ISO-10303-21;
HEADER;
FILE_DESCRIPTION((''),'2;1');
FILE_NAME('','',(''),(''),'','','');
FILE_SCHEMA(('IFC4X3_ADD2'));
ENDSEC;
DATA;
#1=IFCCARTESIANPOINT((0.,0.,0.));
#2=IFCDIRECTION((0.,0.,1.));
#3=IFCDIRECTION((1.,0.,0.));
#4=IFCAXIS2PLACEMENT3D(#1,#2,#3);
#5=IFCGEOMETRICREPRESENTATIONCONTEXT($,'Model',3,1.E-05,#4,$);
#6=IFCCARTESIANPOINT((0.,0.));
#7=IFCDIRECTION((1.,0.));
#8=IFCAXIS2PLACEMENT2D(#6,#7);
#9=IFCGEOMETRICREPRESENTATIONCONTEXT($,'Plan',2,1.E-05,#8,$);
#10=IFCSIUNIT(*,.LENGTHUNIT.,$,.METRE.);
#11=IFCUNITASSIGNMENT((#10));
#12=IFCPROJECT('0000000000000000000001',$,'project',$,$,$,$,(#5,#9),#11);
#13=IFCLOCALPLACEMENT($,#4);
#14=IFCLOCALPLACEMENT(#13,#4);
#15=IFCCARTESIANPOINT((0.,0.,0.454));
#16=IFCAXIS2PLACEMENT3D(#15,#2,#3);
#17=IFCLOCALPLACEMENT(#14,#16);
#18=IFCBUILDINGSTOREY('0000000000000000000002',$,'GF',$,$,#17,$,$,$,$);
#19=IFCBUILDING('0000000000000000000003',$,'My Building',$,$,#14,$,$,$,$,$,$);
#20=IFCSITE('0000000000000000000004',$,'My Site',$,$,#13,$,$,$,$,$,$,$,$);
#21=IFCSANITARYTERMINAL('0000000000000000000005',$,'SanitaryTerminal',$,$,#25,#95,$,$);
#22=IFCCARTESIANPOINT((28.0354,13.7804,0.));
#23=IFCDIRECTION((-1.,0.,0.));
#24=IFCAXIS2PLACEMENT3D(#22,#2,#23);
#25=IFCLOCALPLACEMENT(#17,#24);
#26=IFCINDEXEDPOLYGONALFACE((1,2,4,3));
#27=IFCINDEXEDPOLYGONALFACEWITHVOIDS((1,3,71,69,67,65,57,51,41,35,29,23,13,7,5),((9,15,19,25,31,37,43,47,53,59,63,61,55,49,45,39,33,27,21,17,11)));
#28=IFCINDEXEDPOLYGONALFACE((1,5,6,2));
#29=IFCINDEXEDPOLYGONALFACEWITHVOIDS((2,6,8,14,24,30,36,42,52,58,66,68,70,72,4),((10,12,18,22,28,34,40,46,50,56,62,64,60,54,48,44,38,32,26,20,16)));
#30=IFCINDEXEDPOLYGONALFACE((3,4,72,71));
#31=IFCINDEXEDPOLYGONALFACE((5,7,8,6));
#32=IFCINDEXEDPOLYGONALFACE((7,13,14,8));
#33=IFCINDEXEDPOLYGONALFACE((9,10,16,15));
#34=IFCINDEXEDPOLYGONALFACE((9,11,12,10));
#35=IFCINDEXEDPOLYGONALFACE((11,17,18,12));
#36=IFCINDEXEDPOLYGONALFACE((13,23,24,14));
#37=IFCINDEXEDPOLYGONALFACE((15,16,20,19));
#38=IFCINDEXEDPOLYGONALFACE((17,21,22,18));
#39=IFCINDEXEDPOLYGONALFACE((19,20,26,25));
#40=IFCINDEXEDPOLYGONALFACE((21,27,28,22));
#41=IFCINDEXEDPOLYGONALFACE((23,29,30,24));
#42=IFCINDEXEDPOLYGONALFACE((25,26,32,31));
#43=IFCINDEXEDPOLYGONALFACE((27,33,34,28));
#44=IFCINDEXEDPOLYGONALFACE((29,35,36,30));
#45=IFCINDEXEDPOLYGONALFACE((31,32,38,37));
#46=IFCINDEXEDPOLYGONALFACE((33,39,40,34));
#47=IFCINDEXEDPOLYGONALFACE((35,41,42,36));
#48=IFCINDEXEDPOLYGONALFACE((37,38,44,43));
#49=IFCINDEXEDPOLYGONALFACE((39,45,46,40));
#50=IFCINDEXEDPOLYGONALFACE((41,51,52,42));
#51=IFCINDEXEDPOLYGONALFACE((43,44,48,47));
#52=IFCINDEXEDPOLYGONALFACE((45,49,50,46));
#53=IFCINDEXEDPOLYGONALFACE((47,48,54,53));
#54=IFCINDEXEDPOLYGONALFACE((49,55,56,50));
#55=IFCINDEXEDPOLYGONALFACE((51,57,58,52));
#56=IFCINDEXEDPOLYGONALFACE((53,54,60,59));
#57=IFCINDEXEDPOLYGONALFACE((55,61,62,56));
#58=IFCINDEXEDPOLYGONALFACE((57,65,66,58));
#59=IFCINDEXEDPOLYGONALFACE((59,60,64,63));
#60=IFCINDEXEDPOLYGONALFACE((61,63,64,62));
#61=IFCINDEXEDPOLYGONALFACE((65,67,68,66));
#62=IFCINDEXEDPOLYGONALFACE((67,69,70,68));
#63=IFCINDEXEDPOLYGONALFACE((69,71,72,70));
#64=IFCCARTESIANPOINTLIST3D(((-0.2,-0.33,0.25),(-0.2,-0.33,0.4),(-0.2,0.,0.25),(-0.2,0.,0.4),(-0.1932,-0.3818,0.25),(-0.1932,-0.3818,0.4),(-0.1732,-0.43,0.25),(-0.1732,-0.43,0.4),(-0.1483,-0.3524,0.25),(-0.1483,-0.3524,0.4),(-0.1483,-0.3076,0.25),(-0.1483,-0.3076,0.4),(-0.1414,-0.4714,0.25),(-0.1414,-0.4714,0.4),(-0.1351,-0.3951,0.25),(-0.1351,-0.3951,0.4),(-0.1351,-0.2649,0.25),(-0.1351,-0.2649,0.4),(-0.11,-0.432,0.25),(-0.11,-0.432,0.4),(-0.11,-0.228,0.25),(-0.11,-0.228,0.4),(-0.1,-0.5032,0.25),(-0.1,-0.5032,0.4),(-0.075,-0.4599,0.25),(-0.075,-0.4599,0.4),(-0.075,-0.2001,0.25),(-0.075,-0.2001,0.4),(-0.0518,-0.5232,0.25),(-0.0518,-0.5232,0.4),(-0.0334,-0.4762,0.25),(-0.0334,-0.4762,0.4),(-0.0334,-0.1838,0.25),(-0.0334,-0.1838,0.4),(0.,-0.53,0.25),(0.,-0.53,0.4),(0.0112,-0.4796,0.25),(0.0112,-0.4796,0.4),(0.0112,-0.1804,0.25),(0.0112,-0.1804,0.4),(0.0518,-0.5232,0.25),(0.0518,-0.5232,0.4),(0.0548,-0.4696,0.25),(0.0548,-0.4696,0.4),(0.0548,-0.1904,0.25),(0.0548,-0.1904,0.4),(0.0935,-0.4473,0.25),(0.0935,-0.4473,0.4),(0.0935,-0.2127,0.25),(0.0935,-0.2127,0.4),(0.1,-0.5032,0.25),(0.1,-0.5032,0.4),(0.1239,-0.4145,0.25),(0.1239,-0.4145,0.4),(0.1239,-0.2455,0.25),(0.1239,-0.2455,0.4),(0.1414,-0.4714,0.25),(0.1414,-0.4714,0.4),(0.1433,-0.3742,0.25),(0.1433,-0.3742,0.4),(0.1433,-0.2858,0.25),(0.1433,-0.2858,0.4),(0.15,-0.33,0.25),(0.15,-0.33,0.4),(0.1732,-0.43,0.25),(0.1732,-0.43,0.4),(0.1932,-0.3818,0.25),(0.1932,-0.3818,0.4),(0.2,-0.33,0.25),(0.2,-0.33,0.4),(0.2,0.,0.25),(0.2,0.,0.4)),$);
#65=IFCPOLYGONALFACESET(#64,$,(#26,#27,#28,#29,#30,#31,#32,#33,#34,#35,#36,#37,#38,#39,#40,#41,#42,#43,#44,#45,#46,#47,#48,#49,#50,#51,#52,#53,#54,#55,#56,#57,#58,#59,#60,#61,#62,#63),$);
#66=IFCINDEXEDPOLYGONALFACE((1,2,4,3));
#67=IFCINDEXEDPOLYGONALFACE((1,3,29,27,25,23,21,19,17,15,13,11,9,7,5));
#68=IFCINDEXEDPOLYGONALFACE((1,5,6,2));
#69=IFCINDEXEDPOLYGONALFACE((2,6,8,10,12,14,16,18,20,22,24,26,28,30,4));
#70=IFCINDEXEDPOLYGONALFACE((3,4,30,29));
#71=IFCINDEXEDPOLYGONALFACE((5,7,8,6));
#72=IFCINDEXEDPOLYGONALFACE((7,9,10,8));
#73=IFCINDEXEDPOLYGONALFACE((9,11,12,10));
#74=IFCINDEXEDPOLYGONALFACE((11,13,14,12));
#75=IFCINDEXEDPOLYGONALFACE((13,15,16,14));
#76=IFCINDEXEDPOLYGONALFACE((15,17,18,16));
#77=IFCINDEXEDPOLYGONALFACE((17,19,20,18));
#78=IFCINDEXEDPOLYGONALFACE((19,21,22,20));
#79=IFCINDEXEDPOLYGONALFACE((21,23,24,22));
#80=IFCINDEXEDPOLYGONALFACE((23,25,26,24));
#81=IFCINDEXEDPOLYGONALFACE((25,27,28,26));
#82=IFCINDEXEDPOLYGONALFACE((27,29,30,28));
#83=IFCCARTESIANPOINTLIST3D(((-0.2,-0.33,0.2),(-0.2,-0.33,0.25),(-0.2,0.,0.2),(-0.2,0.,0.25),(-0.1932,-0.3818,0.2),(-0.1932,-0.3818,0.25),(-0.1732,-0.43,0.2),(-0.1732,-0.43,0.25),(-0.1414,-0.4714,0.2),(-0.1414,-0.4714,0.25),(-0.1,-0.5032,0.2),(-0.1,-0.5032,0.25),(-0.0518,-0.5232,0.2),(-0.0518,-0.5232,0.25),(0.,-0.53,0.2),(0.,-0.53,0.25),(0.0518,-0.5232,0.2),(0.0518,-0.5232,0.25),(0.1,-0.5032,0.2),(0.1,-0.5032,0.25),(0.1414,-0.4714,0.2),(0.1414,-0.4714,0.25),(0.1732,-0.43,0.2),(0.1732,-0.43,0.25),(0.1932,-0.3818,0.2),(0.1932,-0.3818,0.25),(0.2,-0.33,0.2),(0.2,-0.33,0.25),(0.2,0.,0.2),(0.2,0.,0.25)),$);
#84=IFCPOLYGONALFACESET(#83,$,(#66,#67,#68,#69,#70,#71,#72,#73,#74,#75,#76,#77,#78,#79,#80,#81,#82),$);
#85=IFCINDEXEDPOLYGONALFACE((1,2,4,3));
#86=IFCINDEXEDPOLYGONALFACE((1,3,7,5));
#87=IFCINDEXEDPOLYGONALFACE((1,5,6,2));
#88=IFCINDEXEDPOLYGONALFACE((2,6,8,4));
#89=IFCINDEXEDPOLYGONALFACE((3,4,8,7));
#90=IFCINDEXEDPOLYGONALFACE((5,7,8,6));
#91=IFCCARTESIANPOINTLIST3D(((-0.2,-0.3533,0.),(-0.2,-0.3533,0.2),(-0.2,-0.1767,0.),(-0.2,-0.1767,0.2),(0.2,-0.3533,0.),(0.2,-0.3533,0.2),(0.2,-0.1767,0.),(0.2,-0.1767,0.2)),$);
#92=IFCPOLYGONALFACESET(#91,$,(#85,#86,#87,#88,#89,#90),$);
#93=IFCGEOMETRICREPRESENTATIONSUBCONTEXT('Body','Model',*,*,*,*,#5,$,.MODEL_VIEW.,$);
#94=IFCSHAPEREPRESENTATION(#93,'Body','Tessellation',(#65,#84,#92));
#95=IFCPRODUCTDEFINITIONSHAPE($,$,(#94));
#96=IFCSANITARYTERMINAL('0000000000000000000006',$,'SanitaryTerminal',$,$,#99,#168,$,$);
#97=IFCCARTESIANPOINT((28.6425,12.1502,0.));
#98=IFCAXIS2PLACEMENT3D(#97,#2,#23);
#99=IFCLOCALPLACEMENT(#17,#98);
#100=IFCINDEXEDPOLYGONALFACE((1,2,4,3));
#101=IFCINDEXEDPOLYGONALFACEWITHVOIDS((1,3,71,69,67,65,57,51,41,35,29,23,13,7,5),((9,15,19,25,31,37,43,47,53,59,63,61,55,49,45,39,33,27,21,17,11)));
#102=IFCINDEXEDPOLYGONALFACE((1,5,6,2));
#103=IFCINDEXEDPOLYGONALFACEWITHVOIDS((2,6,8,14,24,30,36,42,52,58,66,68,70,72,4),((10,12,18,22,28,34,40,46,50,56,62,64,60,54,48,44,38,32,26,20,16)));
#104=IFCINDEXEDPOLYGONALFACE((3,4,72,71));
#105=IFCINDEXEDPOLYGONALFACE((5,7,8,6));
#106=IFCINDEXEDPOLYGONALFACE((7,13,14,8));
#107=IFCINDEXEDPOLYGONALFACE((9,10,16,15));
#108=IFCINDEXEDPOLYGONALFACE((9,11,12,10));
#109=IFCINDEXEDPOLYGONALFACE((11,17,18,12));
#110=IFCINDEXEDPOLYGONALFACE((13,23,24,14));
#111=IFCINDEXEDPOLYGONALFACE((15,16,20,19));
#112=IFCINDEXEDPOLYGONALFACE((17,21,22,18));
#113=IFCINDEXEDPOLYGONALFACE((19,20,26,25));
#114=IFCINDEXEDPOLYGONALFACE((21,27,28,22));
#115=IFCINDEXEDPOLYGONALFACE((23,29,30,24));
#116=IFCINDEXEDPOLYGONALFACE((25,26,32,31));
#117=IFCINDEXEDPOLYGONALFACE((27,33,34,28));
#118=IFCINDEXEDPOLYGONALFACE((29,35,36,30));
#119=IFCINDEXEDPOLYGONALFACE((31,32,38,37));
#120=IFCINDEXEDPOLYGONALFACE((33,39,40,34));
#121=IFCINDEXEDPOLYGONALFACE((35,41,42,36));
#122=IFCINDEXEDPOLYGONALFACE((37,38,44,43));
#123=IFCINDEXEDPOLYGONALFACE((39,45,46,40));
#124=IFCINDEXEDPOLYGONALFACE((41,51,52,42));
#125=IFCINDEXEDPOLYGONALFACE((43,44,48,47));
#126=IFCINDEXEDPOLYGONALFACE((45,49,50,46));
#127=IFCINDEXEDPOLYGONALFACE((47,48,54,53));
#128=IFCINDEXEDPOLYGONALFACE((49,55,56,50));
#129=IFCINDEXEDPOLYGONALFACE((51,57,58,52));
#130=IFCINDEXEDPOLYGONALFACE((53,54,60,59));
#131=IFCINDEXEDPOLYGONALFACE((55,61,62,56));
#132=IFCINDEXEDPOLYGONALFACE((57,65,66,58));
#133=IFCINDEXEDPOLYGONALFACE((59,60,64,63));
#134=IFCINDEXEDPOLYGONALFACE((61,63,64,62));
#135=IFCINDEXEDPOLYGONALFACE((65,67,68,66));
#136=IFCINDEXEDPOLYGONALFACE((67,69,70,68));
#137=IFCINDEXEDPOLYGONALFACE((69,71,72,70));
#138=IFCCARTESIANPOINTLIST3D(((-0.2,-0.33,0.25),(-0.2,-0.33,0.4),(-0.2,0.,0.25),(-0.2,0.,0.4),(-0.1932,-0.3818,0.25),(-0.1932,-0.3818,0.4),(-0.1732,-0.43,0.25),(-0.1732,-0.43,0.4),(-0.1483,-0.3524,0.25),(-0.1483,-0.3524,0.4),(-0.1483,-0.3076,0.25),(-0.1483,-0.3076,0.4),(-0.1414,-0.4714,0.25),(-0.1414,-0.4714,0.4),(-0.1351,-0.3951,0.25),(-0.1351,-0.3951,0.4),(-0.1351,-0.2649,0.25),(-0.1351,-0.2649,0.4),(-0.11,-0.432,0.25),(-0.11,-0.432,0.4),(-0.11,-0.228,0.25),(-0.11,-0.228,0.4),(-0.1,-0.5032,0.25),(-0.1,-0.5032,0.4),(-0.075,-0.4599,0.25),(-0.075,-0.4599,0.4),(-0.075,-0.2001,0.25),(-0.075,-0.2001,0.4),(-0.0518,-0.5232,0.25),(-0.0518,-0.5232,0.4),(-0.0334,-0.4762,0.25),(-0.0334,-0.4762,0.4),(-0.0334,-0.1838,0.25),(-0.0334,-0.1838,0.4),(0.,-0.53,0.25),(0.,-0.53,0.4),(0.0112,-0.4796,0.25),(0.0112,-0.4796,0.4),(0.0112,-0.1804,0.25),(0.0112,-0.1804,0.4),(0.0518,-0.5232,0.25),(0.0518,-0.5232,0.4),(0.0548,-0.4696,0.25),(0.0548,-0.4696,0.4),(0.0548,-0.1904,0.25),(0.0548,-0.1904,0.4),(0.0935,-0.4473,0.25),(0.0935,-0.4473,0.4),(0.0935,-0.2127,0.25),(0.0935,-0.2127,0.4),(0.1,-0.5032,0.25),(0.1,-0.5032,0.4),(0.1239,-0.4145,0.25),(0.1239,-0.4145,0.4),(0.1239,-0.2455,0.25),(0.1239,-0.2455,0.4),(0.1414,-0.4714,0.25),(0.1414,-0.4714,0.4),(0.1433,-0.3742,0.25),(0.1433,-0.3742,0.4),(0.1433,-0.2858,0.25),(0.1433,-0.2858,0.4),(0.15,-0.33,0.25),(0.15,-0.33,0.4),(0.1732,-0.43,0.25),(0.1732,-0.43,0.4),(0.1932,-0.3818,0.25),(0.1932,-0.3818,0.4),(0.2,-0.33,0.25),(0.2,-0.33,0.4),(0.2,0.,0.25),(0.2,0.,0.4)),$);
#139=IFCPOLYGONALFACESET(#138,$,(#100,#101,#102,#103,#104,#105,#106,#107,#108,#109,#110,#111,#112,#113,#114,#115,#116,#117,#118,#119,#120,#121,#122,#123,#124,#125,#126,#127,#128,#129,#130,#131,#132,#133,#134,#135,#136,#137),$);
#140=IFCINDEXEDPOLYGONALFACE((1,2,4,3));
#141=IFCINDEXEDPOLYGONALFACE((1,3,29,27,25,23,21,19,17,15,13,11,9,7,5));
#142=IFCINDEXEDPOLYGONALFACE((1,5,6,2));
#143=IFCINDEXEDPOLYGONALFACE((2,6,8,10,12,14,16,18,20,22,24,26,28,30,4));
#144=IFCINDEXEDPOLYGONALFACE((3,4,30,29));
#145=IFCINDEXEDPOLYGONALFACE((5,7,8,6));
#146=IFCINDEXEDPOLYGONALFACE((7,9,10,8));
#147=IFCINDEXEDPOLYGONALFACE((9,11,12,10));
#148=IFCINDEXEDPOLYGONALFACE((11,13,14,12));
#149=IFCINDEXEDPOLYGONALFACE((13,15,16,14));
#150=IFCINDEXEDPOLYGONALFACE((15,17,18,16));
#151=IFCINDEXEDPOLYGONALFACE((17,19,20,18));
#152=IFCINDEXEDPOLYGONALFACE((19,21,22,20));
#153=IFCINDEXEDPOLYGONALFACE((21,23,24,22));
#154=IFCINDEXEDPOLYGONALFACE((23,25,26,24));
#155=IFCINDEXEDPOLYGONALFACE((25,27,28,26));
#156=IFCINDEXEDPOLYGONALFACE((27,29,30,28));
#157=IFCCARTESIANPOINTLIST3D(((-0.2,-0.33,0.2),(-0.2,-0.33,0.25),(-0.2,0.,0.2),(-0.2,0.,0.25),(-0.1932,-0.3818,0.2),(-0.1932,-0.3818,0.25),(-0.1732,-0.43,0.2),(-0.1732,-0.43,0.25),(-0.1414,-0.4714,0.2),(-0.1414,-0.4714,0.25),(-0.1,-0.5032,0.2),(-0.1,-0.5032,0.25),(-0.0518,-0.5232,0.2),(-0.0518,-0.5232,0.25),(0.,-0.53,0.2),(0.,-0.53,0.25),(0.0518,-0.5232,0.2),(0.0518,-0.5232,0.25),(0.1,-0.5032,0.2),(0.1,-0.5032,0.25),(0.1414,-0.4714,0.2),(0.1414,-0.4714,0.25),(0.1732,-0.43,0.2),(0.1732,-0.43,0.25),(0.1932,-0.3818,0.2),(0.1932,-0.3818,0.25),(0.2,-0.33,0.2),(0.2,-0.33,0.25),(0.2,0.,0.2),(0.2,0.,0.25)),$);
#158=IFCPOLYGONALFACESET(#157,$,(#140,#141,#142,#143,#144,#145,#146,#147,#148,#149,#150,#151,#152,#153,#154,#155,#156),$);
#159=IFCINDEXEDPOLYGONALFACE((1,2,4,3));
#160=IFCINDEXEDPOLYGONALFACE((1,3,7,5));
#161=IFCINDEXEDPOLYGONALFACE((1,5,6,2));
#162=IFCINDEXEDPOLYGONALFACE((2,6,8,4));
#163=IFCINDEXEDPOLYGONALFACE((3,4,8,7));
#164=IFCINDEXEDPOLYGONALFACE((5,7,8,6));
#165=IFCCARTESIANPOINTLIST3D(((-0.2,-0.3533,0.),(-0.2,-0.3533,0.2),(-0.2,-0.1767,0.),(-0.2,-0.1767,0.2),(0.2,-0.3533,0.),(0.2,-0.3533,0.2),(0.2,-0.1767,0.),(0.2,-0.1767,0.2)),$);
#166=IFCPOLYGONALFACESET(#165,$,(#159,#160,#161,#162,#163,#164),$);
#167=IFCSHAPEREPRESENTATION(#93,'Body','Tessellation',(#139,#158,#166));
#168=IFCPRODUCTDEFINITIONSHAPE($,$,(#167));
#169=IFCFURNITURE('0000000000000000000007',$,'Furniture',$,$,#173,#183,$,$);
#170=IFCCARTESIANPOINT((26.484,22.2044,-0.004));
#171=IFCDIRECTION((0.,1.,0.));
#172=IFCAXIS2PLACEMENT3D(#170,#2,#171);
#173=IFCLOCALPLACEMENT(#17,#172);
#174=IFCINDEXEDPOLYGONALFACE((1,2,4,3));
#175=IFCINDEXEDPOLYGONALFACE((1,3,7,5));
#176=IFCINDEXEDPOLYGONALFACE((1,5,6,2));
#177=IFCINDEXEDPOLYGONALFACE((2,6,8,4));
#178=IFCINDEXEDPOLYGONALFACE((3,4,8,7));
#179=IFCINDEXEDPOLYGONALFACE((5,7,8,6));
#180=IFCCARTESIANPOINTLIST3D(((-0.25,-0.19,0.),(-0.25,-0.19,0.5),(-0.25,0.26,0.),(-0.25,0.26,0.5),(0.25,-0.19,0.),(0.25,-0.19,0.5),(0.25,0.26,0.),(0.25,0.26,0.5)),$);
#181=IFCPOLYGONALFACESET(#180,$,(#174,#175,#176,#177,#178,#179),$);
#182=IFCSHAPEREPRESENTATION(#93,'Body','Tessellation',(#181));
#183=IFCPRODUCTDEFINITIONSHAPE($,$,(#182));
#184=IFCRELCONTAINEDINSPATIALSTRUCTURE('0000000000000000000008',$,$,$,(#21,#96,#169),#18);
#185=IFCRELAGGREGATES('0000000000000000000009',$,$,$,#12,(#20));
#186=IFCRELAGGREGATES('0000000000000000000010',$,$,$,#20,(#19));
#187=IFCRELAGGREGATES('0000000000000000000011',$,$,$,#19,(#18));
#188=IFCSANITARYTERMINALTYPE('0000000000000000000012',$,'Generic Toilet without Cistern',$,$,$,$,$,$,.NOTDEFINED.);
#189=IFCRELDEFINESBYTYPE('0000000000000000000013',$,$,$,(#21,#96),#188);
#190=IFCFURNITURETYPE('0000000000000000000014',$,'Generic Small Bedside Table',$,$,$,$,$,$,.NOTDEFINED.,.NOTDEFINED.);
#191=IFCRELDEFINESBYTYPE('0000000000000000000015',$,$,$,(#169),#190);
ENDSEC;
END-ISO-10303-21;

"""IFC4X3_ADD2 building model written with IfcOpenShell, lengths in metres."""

from ifc_helpers import new_model, entity, si_unit, frame, frame_2d, origin_with_axes, origin_2d_with_axis, place, context, subcontext, project, spatial, line, arc, indexed_curve, circle_curve, outline, extrude, shape, source, transform, mapped, type_object, type_shapes, element, save


model = new_model("IFC4X3_ADD2")

# Units and contexts
model_context = context("Model", 3, precision=1e-05, world=origin_with_axes())
plan_context = context("Plan", 2, precision=1e-05, world=origin_2d_with_axis())
body_context_1 = subcontext(model_context, "Body", "Model", "MODEL_VIEW")
body_context_2 = subcontext(plan_context, "Body", "Plan", "PLAN_VIEW")
ifc_project = project(units=[si_unit("LENGTHUNIT", "METRE")], contexts=[model_context, plan_context])

# Site, building, storey
site_placement = place(None, origin_with_axes())
site = spatial("IfcSite", under=ifc_project, at=site_placement, Name="My Site")
building_placement = place(site_placement, origin_with_axes())
building = spatial("IfcBuilding", under=site, at=building_placement, Name="My Building")
storey_placement = place(building_placement, frame((0.0, 0.0, 0.454), z_axis=(0.0, 0.0, 1.0), x_axis=(1.0, 0.0, 0.0)))
storey = spatial("IfcBuildingStorey", under=building, at=storey_placement, Name="GF")

# Sanitary terminals
sanitary_terminal_type_1 = type_object("IfcSanitaryTerminalType", Name="Generic Toilet without Cistern", PredefinedType="NOTDEFINED")
shared_shape_1 = source(origin_with_axes(), body_context_1, "Body", "SweptSolid", [
    extrude(outline(indexed_curve([(-0.2, 0.0), (0.2, 0.0), (0.2, -0.33), (0.1414, -0.4714), (0.0, -0.53), (-0.1414, -0.4714), (-0.2, -0.33)], segments=[line(1, 2), line(2, 3), arc(3, 4, 5), arc(5, 6, 7), line(7, 1)]), holes=[circle_curve(frame_2d((0.0, -0.33)), 0.15)]), frame((0.0, 0.0, 0.25), z_axis=(0.0, 0.0, 1.0), x_axis=(1.0, 0.0, 0.0)), (0.0, 0.0, 1.0), 0.15),
    extrude(outline(indexed_curve([(-0.2, 0.0), (0.2, 0.0), (0.2, -0.33), (0.1414, -0.4714), (0.0, -0.53), (-0.1414, -0.4714), (-0.2, -0.33)], segments=[line(1, 2), line(2, 3), arc(3, 4, 5), arc(5, 6, 7), line(7, 1)])), frame((0.0, 0.0, 0.2), z_axis=(0.0, 0.0, 1.0), x_axis=(1.0, 0.0, 0.0)), (0.0, 0.0, 1.0), 0.05),
    extrude(outline(indexed_curve([(-0.2, -0.1767), (0.2, -0.1767), (0.2, -0.3533), (-0.2, -0.3533)], segments=[line(1, 2, 3, 4, 1)])), origin_with_axes(), (0.0, 0.0, 1.0), 0.2),
])
shared_shape_2 = source(origin_with_axes(), body_context_2, "Body", "Annotation2D", [
    entity("IfcGeometricCurveSet", [entity("IfcIndexedPolyCurve", entity("IfcCartesianPointList2D", [[-0.1068, -0.124], [-0.0957, -0.1129], [-0.0804, -0.1088], [0.0804, -0.1088], [0.0957, -0.1129], [0.1068, -0.124], [0.1109, -0.1393], [0.1109, -0.3476], [0.1025, -0.3926], [0.0784, -0.4308], [0.0424, -0.4563], [0.0, -0.4652], [-0.0424, -0.4563], [-0.0784, -0.4308], [-0.1025, -0.3926], [-0.1109, -0.3476], [-0.1109, -0.1393]]), [entity("IfcLineIndex", [1, 2, 3, 4, 5, 6, 7, 8, 9, 10, 11, 12, 13, 14, 15, 16, 17, 1])]), entity("IfcIndexedPolyCurve", entity("IfcCartesianPointList2D", [[-0.1962, -0.2314], [-0.1848, -0.301], [-0.1764, -0.3339], [-0.1663, -0.3651], [-0.1546, -0.3944], [-0.1414, -0.4213], [-0.1269, -0.4458], [-0.1111, -0.4675], [-0.0943, -0.4862], [-0.0765, -0.5018], [-0.0581, -0.514], [-0.039, -0.5229], [-0.0196, -0.5282], [0.0, -0.53], [0.0196, -0.5282], [0.039, -0.5229], [0.0581, -0.514], [0.0765, -0.5018], [0.0943, -0.4862], [0.1111, -0.4675], [0.1269, -0.4458], [0.1414, -0.4213], [0.1546, -0.3944], [0.1663, -0.3651], [0.1764, -0.3339], [0.1848, -0.301], [0.1962, -0.2314], [0.2, -0.159], [0.1872, 0.0], [-0.1872, 0.0], [-0.2, -0.159]]), [entity("IfcLineIndex", [1, 2, 3, 4, 5, 6, 7, 8, 9, 10, 11, 12, 13, 14, 15, 16, 17, 18, 19, 20, 21, 22, 23, 24, 25, 26, 27, 28, 29, 30, 31, 1])])]),
])
type_shapes(sanitary_terminal_type_1, [shared_shape_1, shared_shape_2])
for number, where, z_axis, x_axis, name in (
    (1, (28.0354, 13.7804, 0.0), (0.0, 0.0, 1.0), (-1.0, 0.0, 0.0), "SanitaryTerminal"),
    (2, (28.6425, 12.1502, 0.0), (0.0, 0.0, 1.0), (-1.0, 0.0, 0.0), "SanitaryTerminal"),
):
    element("IfcSanitaryTerminal", number, at=place(storey_placement, frame(where, z_axis=z_axis, x_axis=x_axis)), inside=storey, type_object=sanitary_terminal_type_1, Name=name, shapes=[
        shape(body_context_1, "Body", "MappedRepresentation", [mapped(shared_shape_1, transform((0.0, 0.0, 0.0), x_axis=(1.0, 0.0, 0.0), y_axis=(0.0, 1.0, 0.0), z_axis=(0.0, 0.0, 1.0), scale=1.0))]),
        shape(body_context_2, "Body", "MappedRepresentation", [mapped(shared_shape_2, transform((0.0, 0.0, 0.0), x_axis=(1.0, 0.0, 0.0), y_axis=(0.0, 1.0, 0.0), z_axis=(0.0, 0.0, 1.0), scale=1.0))]),
    ])

# Furniture
furniture_type_1 = type_object("IfcFurnitureType", Name="Generic Small Bedside Table", AssemblyPlace="NOTDEFINED", PredefinedType="NOTDEFINED")
shared_shape_3 = source(origin_with_axes(), body_context_1, "Body", "SweptSolid", [
    extrude(outline(indexed_curve([(0.5, 0.45), (0.5, 0.0), (0.0, 0.0), (0.0, 0.45)], segments=[line(4, 1), line(1, 2), line(2, 3), line(3, 4)], self_intersect=False)), frame((-0.25, -0.19, 0.0), z_axis=(0.0, 0.0, 1.0), x_axis=(1.0, 0.0, 0.0)), (0.0, 0.0, 1.0), 0.5),
])
shared_shape_4 = source(origin_with_axes(), body_context_2, "Body", "Annotation2D", [
    entity("IfcGeometricCurveSet", [entity("IfcIndexedPolyCurve", entity("IfcCartesianPointList2D", [[-0.25, -0.19], [0.25, -0.19], [0.25, 0.26], [-0.25, 0.26]]), [entity("IfcLineIndex", [1, 2]), entity("IfcLineIndex", [2, 3]), entity("IfcLineIndex", [3, 4]), entity("IfcLineIndex", [4, 1])])]),
])
type_shapes(furniture_type_1, [shared_shape_3, shared_shape_4])
for number, where, z_axis, x_axis, name in (
    (3, (26.484, 22.2044, -0.004), (0.0, 0.0, 1.0), (0.0, 1.0, 0.0), "Furniture"),
):
    element("IfcFurniture", number, at=place(storey_placement, frame(where, z_axis=z_axis, x_axis=x_axis)), inside=storey, type_object=furniture_type_1, Name=name, shapes=[
        shape(body_context_1, "Body", "MappedRepresentation", [mapped(shared_shape_3, transform((0.0, 0.0, 0.0), x_axis=(1.0, 0.0, 0.0), y_axis=(0.0, 1.0, 0.0), z_axis=(0.0, 0.0, 1.0), scale=1.0))]),
        shape(body_context_2, "Body", "MappedRepresentation", [mapped(shared_shape_4, transform((0.0, 0.0, 0.0), x_axis=(1.0, 0.0, 0.0), y_axis=(0.0, 1.0, 0.0), z_axis=(0.0, 0.0, 1.0), scale=1.0))]),
    ])

save(model, "model.ifc")
